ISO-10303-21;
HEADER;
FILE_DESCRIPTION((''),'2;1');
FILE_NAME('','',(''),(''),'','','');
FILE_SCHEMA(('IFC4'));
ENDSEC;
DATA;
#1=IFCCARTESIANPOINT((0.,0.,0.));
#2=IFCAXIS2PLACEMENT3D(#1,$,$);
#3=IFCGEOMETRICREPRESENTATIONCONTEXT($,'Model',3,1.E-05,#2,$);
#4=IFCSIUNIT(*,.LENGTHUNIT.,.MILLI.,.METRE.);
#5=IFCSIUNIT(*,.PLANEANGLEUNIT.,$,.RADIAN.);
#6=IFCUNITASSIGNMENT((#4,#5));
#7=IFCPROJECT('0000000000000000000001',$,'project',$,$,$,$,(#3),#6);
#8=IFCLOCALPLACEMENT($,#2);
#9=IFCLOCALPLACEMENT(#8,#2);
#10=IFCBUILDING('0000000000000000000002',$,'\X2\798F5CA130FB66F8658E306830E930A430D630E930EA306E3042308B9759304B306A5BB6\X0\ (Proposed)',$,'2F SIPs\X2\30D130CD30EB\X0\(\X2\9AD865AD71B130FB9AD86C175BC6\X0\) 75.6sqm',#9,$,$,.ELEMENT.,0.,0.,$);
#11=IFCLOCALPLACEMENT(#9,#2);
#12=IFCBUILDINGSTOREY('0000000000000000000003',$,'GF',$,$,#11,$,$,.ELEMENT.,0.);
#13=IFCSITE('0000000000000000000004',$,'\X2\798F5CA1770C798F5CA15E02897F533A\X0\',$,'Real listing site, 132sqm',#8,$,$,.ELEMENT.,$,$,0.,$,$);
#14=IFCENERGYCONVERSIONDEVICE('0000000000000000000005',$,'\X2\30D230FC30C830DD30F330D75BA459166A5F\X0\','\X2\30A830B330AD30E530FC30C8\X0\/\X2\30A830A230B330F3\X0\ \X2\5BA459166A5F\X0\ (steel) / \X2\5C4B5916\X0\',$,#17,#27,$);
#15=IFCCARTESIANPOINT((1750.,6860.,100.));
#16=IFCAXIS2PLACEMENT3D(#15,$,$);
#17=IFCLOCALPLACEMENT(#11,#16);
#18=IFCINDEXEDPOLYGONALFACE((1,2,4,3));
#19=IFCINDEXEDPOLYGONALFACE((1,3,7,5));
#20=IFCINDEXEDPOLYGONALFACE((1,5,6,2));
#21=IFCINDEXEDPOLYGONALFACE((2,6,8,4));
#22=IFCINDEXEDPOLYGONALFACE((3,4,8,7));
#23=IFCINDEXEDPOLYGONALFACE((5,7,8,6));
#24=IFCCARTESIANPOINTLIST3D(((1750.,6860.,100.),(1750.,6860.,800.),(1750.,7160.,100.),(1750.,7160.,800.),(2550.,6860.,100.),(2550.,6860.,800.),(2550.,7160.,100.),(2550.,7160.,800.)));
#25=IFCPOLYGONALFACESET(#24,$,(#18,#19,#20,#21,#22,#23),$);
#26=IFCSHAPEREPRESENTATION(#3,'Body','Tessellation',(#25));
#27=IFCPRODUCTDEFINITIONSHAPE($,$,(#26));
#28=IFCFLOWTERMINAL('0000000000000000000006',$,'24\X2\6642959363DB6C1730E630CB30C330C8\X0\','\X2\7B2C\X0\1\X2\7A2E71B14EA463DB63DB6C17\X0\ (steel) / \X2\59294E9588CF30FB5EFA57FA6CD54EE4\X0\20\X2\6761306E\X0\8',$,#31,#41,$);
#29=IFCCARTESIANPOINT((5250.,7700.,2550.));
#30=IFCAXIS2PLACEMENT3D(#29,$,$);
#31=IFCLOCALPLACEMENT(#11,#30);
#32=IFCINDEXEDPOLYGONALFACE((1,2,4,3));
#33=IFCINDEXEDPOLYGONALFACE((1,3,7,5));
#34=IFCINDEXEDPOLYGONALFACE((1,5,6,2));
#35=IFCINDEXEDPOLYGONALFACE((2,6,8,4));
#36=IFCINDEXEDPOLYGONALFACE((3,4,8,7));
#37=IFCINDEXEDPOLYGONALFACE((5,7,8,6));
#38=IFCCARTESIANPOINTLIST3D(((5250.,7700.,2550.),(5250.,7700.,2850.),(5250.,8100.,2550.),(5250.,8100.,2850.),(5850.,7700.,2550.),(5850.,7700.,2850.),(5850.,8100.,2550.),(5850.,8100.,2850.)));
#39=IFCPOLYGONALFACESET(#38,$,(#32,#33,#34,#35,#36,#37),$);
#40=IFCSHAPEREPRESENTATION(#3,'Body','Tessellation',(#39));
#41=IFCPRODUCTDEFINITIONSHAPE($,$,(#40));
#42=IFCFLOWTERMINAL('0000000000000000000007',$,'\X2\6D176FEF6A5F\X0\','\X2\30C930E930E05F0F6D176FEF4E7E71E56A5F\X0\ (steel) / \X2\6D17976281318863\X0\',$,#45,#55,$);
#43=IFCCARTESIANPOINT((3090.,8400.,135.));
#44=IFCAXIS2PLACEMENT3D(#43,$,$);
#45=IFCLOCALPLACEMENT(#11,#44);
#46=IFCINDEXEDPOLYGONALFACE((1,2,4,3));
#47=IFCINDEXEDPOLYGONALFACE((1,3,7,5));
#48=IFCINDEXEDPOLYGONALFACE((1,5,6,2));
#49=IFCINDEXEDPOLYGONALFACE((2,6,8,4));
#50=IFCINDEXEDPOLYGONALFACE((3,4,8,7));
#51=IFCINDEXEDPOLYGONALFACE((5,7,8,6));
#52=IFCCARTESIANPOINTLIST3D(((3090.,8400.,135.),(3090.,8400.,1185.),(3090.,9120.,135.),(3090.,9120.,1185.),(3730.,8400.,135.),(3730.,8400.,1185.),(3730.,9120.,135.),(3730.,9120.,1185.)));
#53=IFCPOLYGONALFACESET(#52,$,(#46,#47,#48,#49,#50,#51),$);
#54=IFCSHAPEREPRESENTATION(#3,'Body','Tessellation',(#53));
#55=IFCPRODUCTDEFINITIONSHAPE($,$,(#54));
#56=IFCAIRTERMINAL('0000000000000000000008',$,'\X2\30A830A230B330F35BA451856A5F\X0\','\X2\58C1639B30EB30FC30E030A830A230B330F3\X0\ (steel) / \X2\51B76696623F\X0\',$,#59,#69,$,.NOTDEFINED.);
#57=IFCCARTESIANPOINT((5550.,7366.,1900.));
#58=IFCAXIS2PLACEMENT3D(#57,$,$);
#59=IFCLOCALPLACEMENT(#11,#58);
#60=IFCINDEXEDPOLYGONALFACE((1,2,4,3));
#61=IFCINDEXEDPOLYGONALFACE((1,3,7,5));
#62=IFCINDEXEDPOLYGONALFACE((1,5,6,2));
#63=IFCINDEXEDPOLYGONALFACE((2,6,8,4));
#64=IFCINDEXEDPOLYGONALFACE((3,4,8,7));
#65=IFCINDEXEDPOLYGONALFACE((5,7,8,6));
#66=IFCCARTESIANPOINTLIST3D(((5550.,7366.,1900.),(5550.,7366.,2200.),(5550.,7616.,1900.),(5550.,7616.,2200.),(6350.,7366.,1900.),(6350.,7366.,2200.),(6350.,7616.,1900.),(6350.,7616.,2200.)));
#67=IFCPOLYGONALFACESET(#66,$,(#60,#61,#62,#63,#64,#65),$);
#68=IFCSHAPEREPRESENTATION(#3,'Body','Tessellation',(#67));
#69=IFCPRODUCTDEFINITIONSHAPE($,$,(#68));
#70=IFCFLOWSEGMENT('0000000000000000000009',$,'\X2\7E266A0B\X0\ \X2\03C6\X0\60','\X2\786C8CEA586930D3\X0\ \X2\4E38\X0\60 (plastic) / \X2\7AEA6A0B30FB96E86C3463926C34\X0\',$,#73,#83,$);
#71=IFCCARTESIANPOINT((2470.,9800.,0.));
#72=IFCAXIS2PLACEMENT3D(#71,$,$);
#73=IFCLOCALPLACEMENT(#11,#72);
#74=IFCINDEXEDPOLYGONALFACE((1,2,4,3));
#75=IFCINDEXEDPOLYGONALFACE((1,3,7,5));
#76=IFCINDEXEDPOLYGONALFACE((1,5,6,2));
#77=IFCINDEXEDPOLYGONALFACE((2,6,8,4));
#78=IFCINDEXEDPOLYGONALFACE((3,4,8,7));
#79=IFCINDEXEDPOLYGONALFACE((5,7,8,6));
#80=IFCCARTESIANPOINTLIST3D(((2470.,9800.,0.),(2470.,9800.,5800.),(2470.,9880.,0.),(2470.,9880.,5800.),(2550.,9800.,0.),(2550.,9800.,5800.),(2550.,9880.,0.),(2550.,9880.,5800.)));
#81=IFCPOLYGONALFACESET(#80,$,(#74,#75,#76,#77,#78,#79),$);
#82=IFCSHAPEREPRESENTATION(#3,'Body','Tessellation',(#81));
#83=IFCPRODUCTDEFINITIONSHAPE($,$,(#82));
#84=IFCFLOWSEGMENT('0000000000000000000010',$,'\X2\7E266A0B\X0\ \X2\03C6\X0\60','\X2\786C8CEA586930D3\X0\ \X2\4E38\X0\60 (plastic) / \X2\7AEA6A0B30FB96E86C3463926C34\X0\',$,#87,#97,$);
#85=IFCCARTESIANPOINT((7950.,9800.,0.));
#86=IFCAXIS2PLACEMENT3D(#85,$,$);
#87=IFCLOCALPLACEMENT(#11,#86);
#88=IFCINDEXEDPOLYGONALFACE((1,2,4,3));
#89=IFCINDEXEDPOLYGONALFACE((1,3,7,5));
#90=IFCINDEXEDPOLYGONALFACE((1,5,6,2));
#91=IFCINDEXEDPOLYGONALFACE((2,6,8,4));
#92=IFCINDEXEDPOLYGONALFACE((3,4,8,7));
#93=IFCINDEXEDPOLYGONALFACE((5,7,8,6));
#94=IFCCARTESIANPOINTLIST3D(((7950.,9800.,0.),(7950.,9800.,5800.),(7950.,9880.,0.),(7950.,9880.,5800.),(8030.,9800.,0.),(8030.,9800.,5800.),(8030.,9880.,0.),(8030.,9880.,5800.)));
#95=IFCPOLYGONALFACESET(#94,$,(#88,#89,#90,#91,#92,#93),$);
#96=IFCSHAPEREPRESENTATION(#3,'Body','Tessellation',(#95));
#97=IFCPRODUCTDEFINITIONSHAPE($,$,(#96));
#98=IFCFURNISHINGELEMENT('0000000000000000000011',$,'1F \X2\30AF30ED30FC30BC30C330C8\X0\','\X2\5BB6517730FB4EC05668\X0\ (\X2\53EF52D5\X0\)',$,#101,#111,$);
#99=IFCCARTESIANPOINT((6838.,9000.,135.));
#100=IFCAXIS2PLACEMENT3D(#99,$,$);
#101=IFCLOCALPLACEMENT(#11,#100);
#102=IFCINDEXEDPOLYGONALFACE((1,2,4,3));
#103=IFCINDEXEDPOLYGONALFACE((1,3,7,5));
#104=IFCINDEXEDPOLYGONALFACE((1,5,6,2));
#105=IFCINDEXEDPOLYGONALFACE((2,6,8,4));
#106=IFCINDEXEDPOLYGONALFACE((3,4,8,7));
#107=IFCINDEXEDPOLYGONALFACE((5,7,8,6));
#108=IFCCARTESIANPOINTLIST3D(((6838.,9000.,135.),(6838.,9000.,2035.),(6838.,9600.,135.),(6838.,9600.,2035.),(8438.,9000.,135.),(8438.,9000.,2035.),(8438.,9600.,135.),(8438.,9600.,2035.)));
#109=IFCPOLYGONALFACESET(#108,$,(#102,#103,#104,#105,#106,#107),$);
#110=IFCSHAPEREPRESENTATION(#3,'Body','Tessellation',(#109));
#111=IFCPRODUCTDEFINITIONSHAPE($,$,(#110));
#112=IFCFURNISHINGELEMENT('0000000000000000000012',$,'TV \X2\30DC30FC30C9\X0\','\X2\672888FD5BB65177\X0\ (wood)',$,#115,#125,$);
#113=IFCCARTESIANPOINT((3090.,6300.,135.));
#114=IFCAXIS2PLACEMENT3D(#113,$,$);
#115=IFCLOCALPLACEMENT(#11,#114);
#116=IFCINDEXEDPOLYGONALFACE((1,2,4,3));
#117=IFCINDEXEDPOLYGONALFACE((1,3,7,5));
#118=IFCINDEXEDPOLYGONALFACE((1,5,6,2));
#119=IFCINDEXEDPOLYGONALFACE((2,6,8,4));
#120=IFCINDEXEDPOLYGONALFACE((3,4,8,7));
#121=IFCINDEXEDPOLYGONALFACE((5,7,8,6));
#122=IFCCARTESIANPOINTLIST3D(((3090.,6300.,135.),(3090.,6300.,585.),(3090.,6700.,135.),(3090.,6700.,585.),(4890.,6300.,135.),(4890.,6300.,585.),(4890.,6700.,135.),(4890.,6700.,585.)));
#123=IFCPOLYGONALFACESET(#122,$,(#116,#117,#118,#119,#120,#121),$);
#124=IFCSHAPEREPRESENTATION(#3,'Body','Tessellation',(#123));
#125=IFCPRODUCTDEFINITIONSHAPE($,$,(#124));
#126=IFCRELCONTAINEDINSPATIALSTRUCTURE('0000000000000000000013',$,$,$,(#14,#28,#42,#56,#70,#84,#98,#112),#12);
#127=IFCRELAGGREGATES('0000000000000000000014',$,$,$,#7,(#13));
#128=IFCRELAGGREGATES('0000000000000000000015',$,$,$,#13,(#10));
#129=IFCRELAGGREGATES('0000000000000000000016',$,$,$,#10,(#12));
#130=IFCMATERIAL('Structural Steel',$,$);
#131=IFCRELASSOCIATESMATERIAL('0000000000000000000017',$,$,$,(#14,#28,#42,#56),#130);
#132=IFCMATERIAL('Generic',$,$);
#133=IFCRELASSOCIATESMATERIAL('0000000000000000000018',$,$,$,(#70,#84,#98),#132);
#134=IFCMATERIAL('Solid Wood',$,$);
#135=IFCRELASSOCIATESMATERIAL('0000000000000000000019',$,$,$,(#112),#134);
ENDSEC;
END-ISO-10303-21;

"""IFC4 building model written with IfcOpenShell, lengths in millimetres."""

from ifc_helpers import new_model, si_unit, frame, frame_2d, origin, place, context, project, spatial, rectangle, extrude, material, element, save


model = new_model("IFC4")

# Units and contexts
model_context = context("Model", 3, precision=1e-05, world=origin())
ifc_project = project(units=[si_unit("LENGTHUNIT", "METRE", prefix="MILLI"), si_unit("PLANEANGLEUNIT", "RADIAN")], contexts=[model_context])

# Site, building, storey
site_placement = place(None, origin())
site = spatial("IfcSite", under=ifc_project, at=site_placement, Name="福岡県福岡市西区", ObjectType="Real listing site, 132sqm", CompositionType="ELEMENT", RefElevation=0.0)
building_placement = place(site_placement, origin())
building = spatial("IfcBuilding", under=site, at=building_placement, Name="福岡・書斎とライブラリのある静かな家 (Proposed)", ObjectType="2F SIPsパネル(高断熱・高気密) 75.6sqm", CompositionType="ELEMENT", ElevationOfRefHeight=0.0, ElevationOfTerrain=0.0)
storey_placement = place(building_placement, origin())
storey = spatial("IfcBuildingStorey", under=building, at=storey_placement, Name="GF", CompositionType="ELEMENT", Elevation=0.0)

# Shared definitions
ifc_material_1 = material(Name="Solid Wood")

# Shared definitions
ifc_material_2 = material(Name="Generic")

# Shared definitions
ifc_material_3 = material(Name="Structural Steel")

# Energy conversion device
energy_conversion_device_placement = place(storey_placement, frame((1750.0, 6860.0, 100.0)))
element("IfcEnergyConversionDevice", 1, at=energy_conversion_device_placement, inside=storey, material=ifc_material_3, Name="ヒートポンプ室外機", Description="エコキュート/エアコン 室外機 (steel) / 屋外", context=model_context, shape_type="SweptSolid", body=[
    extrude(rectangle(XDim=800.0, YDim=300.0, at=frame_2d((400.0, 150.0))), frame((1750.0, 6860.0, 100.0)), (0.0, 0.0, 1.0), 700.0),
])

# Flow terminals
flow_terminal_1_placement = place(storey_placement, frame((5250.0, 7700.0, 2550.0)))
element("IfcFlowTerminal", 2, at=flow_terminal_1_placement, inside=storey, material=ifc_material_3, Name="24時間換気ユニット", Description="第1種熱交換換気 (steel) / 天井裏・建基法令20条の8", context=model_context, shape_type="SweptSolid", body=[
    extrude(rectangle(XDim=600.0, YDim=400.0, at=frame_2d((300.0, 200.0))), frame((5250.0, 7700.0, 2550.0)), (0.0, 0.0, 1.0), 300.0),
])
flow_terminal_2_placement = place(storey_placement, frame((3090.0, 8400.0, 135.0)))
element("IfcFlowTerminal", 3, at=flow_terminal_2_placement, inside=storey, material=ifc_material_3, Name="洗濯機", Description="ドラム式洗濯乾燥機 (steel) / 洗面脱衣", context=model_context, shape_type="SweptSolid", body=[
    extrude(rectangle(XDim=640.0, YDim=720.0, at=frame_2d((320.0, 360.0))), frame((3090.0, 8400.0, 135.0)), (0.0, 0.0, 1.0), 1050.0),
])

# Air terminal
air_terminal_placement = place(storey_placement, frame((5550.0, 7366.0, 1900.0)))
element("IfcAirTerminal", 4, at=air_terminal_placement, inside=storey, material=ifc_material_3, Name="エアコン室内機", Description="壁掛ルームエアコン (steel) / 冷暖房", PredefinedType="NOTDEFINED", context=model_context, shape_type="SweptSolid", body=[
    extrude(rectangle(XDim=800.0, YDim=250.0, at=frame_2d((400.0, 125.0))), frame((5550.0, 7366.0, 1900.0)), (0.0, 0.0, 1.0), 300.0),
])

# Flow segments
flow_segment_1_placement = place(storey_placement, frame((2470.0, 9800.0, 0.0)))
element("IfcFlowSegment", 5, at=flow_segment_1_placement, inside=storey, material=ifc_material_2, Name="縦樋 φ60", Description="硬質塩ビ 丸60 (plastic) / 竪樋・雨水排水", context=model_context, shape_type="SweptSolid", body=[
    extrude(rectangle(XDim=80.0, YDim=80.0, at=frame_2d((40.0, 40.0))), frame((2470.0, 9800.0, 0.0)), (0.0, 0.0, 1.0), 5800.0),
])
flow_segment_2_placement = place(storey_placement, frame((7950.0, 9800.0, 0.0)))
element("IfcFlowSegment", 6, at=flow_segment_2_placement, inside=storey, material=ifc_material_2, Name="縦樋 φ60", Description="硬質塩ビ 丸60 (plastic) / 竪樋・雨水排水", context=model_context, shape_type="SweptSolid", body=[
    extrude(rectangle(XDim=80.0, YDim=80.0, at=frame_2d((40.0, 40.0))), frame((7950.0, 9800.0, 0.0)), (0.0, 0.0, 1.0), 5800.0),
])

# Furnishing elements
furnishing_1_placement = place(storey_placement, frame((6838.0, 9000.0, 135.0)))
element("IfcFurnishingElement", 7, at=furnishing_1_placement, inside=storey, material=ifc_material_2, Name="1F クローゼット", Description="家具・什器 (可動)", context=model_context, shape_type="SweptSolid", body=[
    extrude(rectangle(XDim=1600.0, YDim=600.0, at=frame_2d((800.0, 300.0))), frame((6838.0, 9000.0, 135.0)), (0.0, 0.0, 1.0), 1900.0),
])
furnishing_2_placement = place(storey_placement, frame((3090.0, 6300.0, 135.0)))
element("IfcFurnishingElement", 8, at=furnishing_2_placement, inside=storey, material=ifc_material_1, Name="TV ボード", Description="木製家具 (wood)", context=model_context, shape_type="SweptSolid", body=[
    extrude(rectangle(XDim=1800.0, YDim=400.0, at=frame_2d((900.0, 200.0))), frame((3090.0, 6300.0, 135.0)), (0.0, 0.0, 1.0), 450.0),
])

save(model, "model.ifc")
